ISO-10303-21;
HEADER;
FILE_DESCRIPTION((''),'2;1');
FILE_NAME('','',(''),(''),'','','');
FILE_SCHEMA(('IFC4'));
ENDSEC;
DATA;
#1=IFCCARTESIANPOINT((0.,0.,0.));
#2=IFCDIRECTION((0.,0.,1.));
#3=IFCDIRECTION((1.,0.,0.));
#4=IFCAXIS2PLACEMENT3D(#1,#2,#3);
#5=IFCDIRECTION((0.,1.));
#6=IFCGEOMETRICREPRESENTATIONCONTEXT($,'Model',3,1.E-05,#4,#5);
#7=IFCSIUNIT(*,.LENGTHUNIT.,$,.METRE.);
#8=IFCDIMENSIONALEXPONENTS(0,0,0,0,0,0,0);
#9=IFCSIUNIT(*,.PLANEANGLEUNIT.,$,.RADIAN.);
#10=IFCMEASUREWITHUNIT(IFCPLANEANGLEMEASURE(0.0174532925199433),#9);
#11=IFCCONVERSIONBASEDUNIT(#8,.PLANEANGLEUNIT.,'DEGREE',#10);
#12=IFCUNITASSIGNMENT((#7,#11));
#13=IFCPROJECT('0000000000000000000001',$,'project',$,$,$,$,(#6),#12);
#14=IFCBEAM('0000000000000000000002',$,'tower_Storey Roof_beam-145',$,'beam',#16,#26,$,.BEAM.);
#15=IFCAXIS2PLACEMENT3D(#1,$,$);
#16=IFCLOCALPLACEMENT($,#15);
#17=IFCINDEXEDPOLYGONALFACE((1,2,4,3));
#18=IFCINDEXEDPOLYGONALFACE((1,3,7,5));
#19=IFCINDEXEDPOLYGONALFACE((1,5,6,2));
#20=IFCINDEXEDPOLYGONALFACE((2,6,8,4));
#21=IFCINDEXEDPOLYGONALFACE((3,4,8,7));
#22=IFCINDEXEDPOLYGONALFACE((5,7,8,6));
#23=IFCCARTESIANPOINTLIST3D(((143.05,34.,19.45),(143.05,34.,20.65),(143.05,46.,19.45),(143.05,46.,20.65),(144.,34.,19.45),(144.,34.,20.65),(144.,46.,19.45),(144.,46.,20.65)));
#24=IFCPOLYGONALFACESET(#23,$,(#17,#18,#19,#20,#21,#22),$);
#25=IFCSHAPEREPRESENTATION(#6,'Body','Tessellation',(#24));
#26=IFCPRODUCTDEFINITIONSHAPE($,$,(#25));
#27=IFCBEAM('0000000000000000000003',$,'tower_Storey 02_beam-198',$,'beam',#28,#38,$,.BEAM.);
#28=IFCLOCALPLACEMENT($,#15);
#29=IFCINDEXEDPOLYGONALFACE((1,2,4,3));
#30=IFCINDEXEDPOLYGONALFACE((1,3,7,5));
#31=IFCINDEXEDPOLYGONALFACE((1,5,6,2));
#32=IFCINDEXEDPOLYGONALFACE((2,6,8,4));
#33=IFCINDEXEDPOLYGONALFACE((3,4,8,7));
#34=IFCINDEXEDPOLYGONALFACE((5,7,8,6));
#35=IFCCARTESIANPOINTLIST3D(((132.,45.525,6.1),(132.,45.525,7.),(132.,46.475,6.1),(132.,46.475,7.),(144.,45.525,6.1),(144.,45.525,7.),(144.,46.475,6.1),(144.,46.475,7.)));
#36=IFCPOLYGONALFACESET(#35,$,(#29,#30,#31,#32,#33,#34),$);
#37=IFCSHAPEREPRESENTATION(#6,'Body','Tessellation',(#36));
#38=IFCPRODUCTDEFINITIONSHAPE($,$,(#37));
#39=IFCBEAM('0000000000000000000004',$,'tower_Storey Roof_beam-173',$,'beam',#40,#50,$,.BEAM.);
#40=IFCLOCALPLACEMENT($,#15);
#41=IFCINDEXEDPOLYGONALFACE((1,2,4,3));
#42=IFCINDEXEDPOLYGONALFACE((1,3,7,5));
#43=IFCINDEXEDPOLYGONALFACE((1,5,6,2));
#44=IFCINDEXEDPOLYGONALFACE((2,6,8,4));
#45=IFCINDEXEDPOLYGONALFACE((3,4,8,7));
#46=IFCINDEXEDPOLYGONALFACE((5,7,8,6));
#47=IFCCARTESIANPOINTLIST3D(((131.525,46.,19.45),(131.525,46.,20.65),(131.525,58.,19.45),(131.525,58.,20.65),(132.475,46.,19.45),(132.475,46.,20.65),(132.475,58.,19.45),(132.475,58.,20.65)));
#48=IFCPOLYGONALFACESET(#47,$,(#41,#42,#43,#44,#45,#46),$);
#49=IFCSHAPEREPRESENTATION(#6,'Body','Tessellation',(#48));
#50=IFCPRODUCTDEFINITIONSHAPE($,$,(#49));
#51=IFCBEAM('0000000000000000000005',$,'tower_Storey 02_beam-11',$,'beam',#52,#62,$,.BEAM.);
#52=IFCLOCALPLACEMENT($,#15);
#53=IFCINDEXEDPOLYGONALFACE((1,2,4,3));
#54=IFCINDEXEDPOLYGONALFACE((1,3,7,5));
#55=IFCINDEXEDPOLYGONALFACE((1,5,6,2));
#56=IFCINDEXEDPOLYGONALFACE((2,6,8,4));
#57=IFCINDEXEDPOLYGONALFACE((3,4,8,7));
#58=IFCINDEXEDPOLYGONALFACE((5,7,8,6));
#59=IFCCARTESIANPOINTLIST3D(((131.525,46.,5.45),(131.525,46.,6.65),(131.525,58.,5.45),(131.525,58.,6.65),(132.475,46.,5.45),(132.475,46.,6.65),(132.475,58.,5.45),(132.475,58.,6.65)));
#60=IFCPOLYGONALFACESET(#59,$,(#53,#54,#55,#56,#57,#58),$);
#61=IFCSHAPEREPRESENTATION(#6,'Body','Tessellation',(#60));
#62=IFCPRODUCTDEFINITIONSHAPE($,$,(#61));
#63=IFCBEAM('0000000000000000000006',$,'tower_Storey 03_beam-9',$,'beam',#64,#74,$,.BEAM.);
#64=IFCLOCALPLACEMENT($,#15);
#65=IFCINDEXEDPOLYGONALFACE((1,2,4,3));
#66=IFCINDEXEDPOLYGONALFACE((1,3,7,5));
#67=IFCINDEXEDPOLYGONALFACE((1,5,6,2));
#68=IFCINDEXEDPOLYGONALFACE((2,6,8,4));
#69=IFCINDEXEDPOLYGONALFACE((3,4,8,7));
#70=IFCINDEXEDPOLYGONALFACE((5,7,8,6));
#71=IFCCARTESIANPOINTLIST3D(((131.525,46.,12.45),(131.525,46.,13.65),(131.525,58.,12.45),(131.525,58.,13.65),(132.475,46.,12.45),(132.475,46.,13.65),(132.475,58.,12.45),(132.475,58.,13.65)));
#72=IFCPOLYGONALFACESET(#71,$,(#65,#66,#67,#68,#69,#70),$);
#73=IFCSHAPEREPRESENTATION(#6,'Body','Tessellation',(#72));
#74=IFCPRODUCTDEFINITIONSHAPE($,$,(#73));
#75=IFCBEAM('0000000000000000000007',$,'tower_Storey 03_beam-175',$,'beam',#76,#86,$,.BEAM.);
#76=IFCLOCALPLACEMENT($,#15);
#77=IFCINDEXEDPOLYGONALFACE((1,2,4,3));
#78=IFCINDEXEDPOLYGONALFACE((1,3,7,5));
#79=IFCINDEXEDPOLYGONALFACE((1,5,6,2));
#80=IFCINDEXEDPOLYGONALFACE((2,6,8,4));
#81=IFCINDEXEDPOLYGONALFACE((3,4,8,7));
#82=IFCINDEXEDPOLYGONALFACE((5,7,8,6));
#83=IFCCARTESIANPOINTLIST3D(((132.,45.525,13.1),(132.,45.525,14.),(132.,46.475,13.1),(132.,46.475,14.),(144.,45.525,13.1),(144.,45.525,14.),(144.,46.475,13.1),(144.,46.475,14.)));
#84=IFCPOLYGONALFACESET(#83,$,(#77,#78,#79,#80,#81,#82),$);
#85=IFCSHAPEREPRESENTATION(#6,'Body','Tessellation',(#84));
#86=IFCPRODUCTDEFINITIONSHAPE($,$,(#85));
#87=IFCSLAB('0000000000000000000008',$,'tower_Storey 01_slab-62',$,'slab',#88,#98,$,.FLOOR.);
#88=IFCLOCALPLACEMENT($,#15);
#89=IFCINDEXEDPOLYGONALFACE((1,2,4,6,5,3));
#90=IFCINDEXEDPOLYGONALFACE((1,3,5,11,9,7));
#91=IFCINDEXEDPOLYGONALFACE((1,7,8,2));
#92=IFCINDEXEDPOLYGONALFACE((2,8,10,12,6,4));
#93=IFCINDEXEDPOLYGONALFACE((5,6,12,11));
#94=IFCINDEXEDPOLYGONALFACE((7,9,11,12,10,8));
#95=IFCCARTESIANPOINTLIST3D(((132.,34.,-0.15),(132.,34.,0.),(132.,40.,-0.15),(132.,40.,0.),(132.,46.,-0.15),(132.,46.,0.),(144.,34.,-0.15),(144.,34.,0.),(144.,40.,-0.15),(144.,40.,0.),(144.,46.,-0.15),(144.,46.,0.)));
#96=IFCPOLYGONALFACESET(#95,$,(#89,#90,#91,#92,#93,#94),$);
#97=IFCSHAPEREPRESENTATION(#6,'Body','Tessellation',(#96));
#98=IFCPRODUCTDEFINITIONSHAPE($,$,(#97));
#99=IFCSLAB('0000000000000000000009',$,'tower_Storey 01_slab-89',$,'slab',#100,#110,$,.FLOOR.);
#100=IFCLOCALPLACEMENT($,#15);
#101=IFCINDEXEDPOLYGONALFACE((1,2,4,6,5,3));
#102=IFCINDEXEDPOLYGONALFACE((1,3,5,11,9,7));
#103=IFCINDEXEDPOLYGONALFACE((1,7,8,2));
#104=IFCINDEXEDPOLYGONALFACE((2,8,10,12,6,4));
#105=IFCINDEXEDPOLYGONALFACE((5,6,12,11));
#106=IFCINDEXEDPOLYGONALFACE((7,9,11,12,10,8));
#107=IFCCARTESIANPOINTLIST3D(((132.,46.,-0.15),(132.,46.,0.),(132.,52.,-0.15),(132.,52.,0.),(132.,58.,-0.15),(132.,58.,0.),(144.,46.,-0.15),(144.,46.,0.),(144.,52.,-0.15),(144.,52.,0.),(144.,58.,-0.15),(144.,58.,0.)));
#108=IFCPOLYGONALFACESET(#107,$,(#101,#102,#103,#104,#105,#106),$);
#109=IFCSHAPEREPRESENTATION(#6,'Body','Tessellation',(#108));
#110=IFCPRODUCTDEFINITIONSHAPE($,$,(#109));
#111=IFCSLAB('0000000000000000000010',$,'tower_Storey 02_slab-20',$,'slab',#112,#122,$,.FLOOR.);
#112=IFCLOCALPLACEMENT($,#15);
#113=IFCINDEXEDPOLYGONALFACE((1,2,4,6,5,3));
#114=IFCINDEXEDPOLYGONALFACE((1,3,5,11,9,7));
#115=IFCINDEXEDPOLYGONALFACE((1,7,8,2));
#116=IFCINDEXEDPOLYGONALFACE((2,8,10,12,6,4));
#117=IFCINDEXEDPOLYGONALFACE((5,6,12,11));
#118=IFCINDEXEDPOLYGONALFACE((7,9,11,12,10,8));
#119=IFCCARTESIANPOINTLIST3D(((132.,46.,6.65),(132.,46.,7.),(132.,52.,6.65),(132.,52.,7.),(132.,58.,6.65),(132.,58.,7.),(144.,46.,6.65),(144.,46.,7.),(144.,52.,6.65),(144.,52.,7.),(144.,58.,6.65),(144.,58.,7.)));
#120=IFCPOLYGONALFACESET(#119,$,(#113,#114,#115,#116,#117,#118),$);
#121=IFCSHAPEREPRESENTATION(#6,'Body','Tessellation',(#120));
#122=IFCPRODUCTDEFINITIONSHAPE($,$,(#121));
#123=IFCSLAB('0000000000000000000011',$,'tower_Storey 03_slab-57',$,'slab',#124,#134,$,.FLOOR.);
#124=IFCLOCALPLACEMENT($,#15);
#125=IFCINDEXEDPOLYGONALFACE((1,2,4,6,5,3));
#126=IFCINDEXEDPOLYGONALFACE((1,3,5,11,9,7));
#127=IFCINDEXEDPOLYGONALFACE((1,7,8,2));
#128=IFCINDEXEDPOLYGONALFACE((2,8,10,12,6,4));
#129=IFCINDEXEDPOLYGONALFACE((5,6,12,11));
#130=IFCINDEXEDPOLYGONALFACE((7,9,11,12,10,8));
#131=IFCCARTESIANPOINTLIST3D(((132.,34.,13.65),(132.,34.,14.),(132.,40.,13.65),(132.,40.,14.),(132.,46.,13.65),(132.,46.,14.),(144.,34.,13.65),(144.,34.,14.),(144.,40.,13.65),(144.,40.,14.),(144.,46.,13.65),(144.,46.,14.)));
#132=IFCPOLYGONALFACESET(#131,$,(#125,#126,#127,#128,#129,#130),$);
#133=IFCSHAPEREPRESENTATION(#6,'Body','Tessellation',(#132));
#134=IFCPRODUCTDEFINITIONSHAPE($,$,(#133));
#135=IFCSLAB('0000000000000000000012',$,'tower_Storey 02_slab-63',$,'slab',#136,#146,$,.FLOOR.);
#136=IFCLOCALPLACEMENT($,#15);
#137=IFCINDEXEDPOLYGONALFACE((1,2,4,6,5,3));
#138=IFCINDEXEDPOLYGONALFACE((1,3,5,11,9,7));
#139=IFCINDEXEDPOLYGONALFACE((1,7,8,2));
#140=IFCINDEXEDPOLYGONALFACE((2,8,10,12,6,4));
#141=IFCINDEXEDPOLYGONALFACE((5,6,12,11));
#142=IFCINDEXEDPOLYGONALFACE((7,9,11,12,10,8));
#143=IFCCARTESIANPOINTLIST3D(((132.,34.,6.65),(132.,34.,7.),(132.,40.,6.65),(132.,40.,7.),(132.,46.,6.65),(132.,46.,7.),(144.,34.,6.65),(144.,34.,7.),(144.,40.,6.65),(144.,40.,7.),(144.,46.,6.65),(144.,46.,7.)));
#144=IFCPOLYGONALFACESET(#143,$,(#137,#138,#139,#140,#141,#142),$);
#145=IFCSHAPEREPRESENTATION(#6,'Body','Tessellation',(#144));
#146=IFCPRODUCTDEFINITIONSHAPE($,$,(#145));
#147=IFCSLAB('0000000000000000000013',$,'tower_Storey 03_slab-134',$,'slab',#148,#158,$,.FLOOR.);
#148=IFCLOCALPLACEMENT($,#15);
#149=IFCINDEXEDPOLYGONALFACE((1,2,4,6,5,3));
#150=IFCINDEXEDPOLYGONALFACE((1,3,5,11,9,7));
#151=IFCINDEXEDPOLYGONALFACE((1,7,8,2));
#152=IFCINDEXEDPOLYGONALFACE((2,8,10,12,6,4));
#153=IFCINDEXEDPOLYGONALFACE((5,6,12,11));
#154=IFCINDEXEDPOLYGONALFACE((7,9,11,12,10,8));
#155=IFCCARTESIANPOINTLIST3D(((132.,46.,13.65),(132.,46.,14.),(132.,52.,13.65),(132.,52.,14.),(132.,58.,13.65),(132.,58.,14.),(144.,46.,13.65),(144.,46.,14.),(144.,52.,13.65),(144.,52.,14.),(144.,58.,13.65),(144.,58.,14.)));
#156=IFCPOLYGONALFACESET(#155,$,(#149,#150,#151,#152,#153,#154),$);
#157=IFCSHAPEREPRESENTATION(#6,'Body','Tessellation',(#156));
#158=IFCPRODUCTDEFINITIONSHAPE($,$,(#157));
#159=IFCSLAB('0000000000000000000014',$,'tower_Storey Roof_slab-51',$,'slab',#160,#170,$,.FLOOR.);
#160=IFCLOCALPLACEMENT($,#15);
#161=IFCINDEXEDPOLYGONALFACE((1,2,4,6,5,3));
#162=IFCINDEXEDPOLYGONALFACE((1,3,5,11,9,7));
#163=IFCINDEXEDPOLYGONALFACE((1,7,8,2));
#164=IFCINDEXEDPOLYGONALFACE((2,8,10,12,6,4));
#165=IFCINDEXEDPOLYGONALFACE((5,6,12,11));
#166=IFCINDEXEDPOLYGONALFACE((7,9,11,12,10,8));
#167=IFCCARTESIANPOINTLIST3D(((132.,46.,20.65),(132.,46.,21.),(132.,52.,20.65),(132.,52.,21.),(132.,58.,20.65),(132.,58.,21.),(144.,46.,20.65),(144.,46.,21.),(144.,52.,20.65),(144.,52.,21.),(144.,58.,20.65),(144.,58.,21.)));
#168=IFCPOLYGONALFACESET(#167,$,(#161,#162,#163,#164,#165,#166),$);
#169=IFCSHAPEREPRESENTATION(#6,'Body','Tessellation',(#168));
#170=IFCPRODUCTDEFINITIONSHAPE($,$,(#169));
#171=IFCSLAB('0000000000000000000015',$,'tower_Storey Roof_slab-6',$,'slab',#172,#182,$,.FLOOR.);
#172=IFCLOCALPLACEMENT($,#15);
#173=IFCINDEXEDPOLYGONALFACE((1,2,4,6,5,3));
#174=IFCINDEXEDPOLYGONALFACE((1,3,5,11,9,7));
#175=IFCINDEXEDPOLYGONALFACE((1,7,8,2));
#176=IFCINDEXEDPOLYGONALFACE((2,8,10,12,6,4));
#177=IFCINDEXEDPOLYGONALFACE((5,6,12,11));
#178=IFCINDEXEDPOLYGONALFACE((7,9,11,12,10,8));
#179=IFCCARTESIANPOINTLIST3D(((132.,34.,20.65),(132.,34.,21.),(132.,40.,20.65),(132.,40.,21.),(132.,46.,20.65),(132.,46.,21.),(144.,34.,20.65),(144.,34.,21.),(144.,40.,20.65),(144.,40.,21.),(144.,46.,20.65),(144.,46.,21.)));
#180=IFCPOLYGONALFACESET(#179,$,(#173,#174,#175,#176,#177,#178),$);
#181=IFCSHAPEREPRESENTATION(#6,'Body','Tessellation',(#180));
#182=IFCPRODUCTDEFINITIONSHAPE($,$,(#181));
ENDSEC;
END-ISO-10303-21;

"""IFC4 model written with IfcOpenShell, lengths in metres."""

from ifc_helpers import new_model, entity, si_unit, converted_unit, direction, frame, origin_with_axes, place, context, project, polyline, outline, extrude, element, save


model = new_model("IFC4")

# Units and contexts
model_context = context("Model", 3, precision=1e-05, world=origin_with_axes(), true_north=direction((0.0, 1.0)))
ifc_project = project(units=[si_unit("LENGTHUNIT", "METRE"), converted_unit("PLANEANGLEUNIT", "DEGREE", entity("IfcPlaneAngleMeasure", 0.0174532925199433), si_unit("PLANEANGLEUNIT", "RADIAN"), dimensions=[0, 0, 0, 0, 0, 0, 0])], contexts=[model_context])

# Shared definitions
placement_1 = place(None, origin_with_axes())
placement_2 = place(placement_1, origin_with_axes())

# Shared definitions
placement_3 = place(placement_1, frame((0.0, 0.0, 14.0), z_axis=(0.0, 0.0, 1.0), x_axis=(1.0, 0.0, 0.0)))
placement_4 = place(placement_1, frame((0.0, 0.0, 7.0), z_axis=(0.0, 0.0, 1.0), x_axis=(1.0, 0.0, 0.0)))

# Beams
placement_5 = place(placement_1, frame((0.0, 0.0, 21.0), z_axis=(0.0, 0.0, 1.0), x_axis=(1.0, 0.0, 0.0)))
beam_1_placement = place(placement_5, frame((143.525, 34.0, -0.95), z_axis=(0.0, 1.0, 0.0), x_axis=(-1.0, 0.0, 0.0)))
element("IfcBeam", 1, at=beam_1_placement, Name="tower_Storey Roof_beam-145", ObjectType="beam", PredefinedType="BEAM", context=model_context, body=[
    extrude(outline(polyline([(0.475, 0.6, 0.0), (-0.475, 0.6, 0.0), (-0.475, -0.6, 0.0), (0.475, -0.6, 0.0), (0.475, 0.6, 0.0)])), origin_with_axes(), (0.0, 0.0, 1.0), 12.0),
])
beam_2_placement = place(placement_4, frame((132.0, 46.0, -0.45), z_axis=(1.0, 0.0, 0.0), x_axis=(0.0, 1.0, 0.0)))
element("IfcBeam", 2, at=beam_2_placement, Name="tower_Storey 02_beam-198", ObjectType="beam", PredefinedType="BEAM", context=model_context, body=[
    extrude(outline(polyline([(0.475, 0.45, 0.0), (-0.475, 0.45, 0.0), (-0.475, -0.45, 0.0), (0.475, -0.45, 0.0), (0.475, 0.45, 0.0)])), origin_with_axes(), (0.0, 0.0, 1.0), 12.0),
])
beam_3_placement = place(placement_5, frame((132.0, 46.0, -0.95), z_axis=(0.0, 1.0, 0.0), x_axis=(-1.0, 0.0, 0.0)))
element("IfcBeam", 3, at=beam_3_placement, Name="tower_Storey Roof_beam-173", ObjectType="beam", PredefinedType="BEAM", context=model_context, body=[
    extrude(outline(polyline([(0.475, 0.6, 0.0), (-0.475, 0.6, 0.0), (-0.475, -0.6, 0.0), (0.475, -0.6, 0.0), (0.475, 0.6, 0.0)])), origin_with_axes(), (0.0, 0.0, 1.0), 12.0),
])
beam_4_placement = place(placement_4, frame((132.0, 46.0, -0.95), z_axis=(0.0, 1.0, 0.0), x_axis=(-1.0, 0.0, 0.0)))
element("IfcBeam", 4, at=beam_4_placement, Name="tower_Storey 02_beam-11", ObjectType="beam", PredefinedType="BEAM", context=model_context, body=[
    extrude(outline(polyline([(0.475, 0.6, 0.0), (-0.475, 0.6, 0.0), (-0.475, -0.6, 0.0), (0.475, -0.6, 0.0), (0.475, 0.6, 0.0)])), origin_with_axes(), (0.0, 0.0, 1.0), 12.0),
])
beam_5_placement = place(placement_3, frame((132.0, 46.0, -0.95), z_axis=(0.0, 1.0, 0.0), x_axis=(-1.0, 0.0, 0.0)))
element("IfcBeam", 5, at=beam_5_placement, Name="tower_Storey 03_beam-9", ObjectType="beam", PredefinedType="BEAM", context=model_context, body=[
    extrude(outline(polyline([(0.475, 0.6, 0.0), (-0.475, 0.6, 0.0), (-0.475, -0.6, 0.0), (0.475, -0.6, 0.0), (0.475, 0.6, 0.0)])), origin_with_axes(), (0.0, 0.0, 1.0), 12.0),
])
beam_6_placement = place(placement_3, frame((132.0, 46.0, -0.45), z_axis=(1.0, 0.0, 0.0), x_axis=(0.0, 1.0, 0.0)))
element("IfcBeam", 6, at=beam_6_placement, Name="tower_Storey 03_beam-175", ObjectType="beam", PredefinedType="BEAM", context=model_context, body=[
    extrude(outline(polyline([(0.475, 0.45, 0.0), (-0.475, 0.45, 0.0), (-0.475, -0.45, 0.0), (0.475, -0.45, 0.0), (0.475, 0.45, 0.0)])), origin_with_axes(), (0.0, 0.0, 1.0), 12.0),
])

# Slabs
slab_1_placement = place(placement_2, frame((138.0, 40.0, -0.15), z_axis=(0.0, 0.0, 1.0), x_axis=(1.0, 0.0, 0.0)))
element("IfcSlab", 7, at=slab_1_placement, Name="tower_Storey 01_slab-62", ObjectType="slab", PredefinedType="FLOOR", context=model_context, body=[
    extrude(outline(polyline([(-6.0, -6.0, 0.0), (6.0, -6.0, 0.0), (6.0, 0.0, 0.0), (6.0, 6.0, 0.0), (-6.0, 6.0, 0.0), (-6.0, 0.0, 0.0), (-6.0, -6.0, 0.0)])), origin_with_axes(), (0.0, 0.0, 1.0), 0.15),
])
slab_2_placement = place(placement_2, frame((138.0, 52.0, -0.15), z_axis=(0.0, 0.0, 1.0), x_axis=(1.0, 0.0, 0.0)))
element("IfcSlab", 8, at=slab_2_placement, Name="tower_Storey 01_slab-89", ObjectType="slab", PredefinedType="FLOOR", context=model_context, body=[
    extrude(outline(polyline([(-6.0, 0.0, 0.0), (-6.0, -6.0, 0.0), (6.0, -6.0, 0.0), (6.0, 0.0, 0.0), (6.0, 6.0, 0.0), (-6.0, 6.0, 0.0), (-6.0, 0.0, 0.0)])), origin_with_axes(), (0.0, 0.0, 1.0), 0.15),
])
slab_3_placement = place(placement_4, frame((138.0, 52.0, -0.35), z_axis=(0.0, 0.0, 1.0), x_axis=(1.0, 0.0, 0.0)))
element("IfcSlab", 9, at=slab_3_placement, Name="tower_Storey 02_slab-20", ObjectType="slab", PredefinedType="FLOOR", context=model_context, body=[
    extrude(outline(polyline([(-6.0, 0.0, 0.0), (-6.0, -6.0, 0.0), (6.0, -6.0, 0.0), (6.0, 0.0, 0.0), (6.0, 6.0, 0.0), (-6.0, 6.0, 0.0), (-6.0, 0.0, 0.0)])), origin_with_axes(), (0.0, 0.0, 1.0), 0.35),
])
slab_4_placement = place(placement_3, frame((138.0, 40.0, -0.35), z_axis=(0.0, 0.0, 1.0), x_axis=(1.0, 0.0, 0.0)))
element("IfcSlab", 10, at=slab_4_placement, Name="tower_Storey 03_slab-57", ObjectType="slab", PredefinedType="FLOOR", context=model_context, body=[
    extrude(outline(polyline([(-6.0, -6.0, 0.0), (6.0, -6.0, 0.0), (6.0, 0.0, 0.0), (6.0, 6.0, 0.0), (-6.0, 6.0, 0.0), (-6.0, 0.0, 0.0), (-6.0, -6.0, 0.0)])), origin_with_axes(), (0.0, 0.0, 1.0), 0.35),
])
slab_5_placement = place(placement_4, frame((138.0, 40.0, -0.35), z_axis=(0.0, 0.0, 1.0), x_axis=(1.0, 0.0, 0.0)))
element("IfcSlab", 11, at=slab_5_placement, Name="tower_Storey 02_slab-63", ObjectType="slab", PredefinedType="FLOOR", context=model_context, body=[
    extrude(outline(polyline([(-6.0, -6.0, 0.0), (6.0, -6.0, 0.0), (6.0, 0.0, 0.0), (6.0, 6.0, 0.0), (-6.0, 6.0, 0.0), (-6.0, 0.0, 0.0), (-6.0, -6.0, 0.0)])), origin_with_axes(), (0.0, 0.0, 1.0), 0.35),
])
slab_6_placement = place(placement_3, frame((138.0, 52.0, -0.35), z_axis=(0.0, 0.0, 1.0), x_axis=(1.0, 0.0, 0.0)))
element("IfcSlab", 12, at=slab_6_placement, Name="tower_Storey 03_slab-134", ObjectType="slab", PredefinedType="FLOOR", context=model_context, body=[
    extrude(outline(polyline([(-6.0, 0.0, 0.0), (-6.0, -6.0, 0.0), (6.0, -6.0, 0.0), (6.0, 0.0, 0.0), (6.0, 6.0, 0.0), (-6.0, 6.0, 0.0), (-6.0, 0.0, 0.0)])), origin_with_axes(), (0.0, 0.0, 1.0), 0.35),
])
slab_7_placement = place(placement_5, frame((138.0, 52.0, -0.35), z_axis=(0.0, 0.0, 1.0), x_axis=(1.0, 0.0, 0.0)))
element("IfcSlab", 13, at=slab_7_placement, Name="tower_Storey Roof_slab-51", ObjectType="slab", PredefinedType="FLOOR", context=model_context, body=[
    extrude(outline(polyline([(-6.0, 0.0, 0.0), (-6.0, -6.0, 0.0), (6.0, -6.0, 0.0), (6.0, 0.0, 0.0), (6.0, 6.0, 0.0), (-6.0, 6.0, 0.0), (-6.0, 0.0, 0.0)])), origin_with_axes(), (0.0, 0.0, 1.0), 0.35),
])
slab_8_placement = place(placement_5, frame((138.0, 40.0, -0.35), z_axis=(0.0, 0.0, 1.0), x_axis=(1.0, 0.0, 0.0)))
element("IfcSlab", 14, at=slab_8_placement, Name="tower_Storey Roof_slab-6", ObjectType="slab", PredefinedType="FLOOR", context=model_context, body=[
    extrude(outline(polyline([(-6.0, -6.0, 0.0), (6.0, -6.0, 0.0), (6.0, 0.0, 0.0), (6.0, 6.0, 0.0), (-6.0, 6.0, 0.0), (-6.0, 0.0, 0.0), (-6.0, -6.0, 0.0)])), origin_with_axes(), (0.0, 0.0, 1.0), 0.35),
])

save(model, "model.ifc")
